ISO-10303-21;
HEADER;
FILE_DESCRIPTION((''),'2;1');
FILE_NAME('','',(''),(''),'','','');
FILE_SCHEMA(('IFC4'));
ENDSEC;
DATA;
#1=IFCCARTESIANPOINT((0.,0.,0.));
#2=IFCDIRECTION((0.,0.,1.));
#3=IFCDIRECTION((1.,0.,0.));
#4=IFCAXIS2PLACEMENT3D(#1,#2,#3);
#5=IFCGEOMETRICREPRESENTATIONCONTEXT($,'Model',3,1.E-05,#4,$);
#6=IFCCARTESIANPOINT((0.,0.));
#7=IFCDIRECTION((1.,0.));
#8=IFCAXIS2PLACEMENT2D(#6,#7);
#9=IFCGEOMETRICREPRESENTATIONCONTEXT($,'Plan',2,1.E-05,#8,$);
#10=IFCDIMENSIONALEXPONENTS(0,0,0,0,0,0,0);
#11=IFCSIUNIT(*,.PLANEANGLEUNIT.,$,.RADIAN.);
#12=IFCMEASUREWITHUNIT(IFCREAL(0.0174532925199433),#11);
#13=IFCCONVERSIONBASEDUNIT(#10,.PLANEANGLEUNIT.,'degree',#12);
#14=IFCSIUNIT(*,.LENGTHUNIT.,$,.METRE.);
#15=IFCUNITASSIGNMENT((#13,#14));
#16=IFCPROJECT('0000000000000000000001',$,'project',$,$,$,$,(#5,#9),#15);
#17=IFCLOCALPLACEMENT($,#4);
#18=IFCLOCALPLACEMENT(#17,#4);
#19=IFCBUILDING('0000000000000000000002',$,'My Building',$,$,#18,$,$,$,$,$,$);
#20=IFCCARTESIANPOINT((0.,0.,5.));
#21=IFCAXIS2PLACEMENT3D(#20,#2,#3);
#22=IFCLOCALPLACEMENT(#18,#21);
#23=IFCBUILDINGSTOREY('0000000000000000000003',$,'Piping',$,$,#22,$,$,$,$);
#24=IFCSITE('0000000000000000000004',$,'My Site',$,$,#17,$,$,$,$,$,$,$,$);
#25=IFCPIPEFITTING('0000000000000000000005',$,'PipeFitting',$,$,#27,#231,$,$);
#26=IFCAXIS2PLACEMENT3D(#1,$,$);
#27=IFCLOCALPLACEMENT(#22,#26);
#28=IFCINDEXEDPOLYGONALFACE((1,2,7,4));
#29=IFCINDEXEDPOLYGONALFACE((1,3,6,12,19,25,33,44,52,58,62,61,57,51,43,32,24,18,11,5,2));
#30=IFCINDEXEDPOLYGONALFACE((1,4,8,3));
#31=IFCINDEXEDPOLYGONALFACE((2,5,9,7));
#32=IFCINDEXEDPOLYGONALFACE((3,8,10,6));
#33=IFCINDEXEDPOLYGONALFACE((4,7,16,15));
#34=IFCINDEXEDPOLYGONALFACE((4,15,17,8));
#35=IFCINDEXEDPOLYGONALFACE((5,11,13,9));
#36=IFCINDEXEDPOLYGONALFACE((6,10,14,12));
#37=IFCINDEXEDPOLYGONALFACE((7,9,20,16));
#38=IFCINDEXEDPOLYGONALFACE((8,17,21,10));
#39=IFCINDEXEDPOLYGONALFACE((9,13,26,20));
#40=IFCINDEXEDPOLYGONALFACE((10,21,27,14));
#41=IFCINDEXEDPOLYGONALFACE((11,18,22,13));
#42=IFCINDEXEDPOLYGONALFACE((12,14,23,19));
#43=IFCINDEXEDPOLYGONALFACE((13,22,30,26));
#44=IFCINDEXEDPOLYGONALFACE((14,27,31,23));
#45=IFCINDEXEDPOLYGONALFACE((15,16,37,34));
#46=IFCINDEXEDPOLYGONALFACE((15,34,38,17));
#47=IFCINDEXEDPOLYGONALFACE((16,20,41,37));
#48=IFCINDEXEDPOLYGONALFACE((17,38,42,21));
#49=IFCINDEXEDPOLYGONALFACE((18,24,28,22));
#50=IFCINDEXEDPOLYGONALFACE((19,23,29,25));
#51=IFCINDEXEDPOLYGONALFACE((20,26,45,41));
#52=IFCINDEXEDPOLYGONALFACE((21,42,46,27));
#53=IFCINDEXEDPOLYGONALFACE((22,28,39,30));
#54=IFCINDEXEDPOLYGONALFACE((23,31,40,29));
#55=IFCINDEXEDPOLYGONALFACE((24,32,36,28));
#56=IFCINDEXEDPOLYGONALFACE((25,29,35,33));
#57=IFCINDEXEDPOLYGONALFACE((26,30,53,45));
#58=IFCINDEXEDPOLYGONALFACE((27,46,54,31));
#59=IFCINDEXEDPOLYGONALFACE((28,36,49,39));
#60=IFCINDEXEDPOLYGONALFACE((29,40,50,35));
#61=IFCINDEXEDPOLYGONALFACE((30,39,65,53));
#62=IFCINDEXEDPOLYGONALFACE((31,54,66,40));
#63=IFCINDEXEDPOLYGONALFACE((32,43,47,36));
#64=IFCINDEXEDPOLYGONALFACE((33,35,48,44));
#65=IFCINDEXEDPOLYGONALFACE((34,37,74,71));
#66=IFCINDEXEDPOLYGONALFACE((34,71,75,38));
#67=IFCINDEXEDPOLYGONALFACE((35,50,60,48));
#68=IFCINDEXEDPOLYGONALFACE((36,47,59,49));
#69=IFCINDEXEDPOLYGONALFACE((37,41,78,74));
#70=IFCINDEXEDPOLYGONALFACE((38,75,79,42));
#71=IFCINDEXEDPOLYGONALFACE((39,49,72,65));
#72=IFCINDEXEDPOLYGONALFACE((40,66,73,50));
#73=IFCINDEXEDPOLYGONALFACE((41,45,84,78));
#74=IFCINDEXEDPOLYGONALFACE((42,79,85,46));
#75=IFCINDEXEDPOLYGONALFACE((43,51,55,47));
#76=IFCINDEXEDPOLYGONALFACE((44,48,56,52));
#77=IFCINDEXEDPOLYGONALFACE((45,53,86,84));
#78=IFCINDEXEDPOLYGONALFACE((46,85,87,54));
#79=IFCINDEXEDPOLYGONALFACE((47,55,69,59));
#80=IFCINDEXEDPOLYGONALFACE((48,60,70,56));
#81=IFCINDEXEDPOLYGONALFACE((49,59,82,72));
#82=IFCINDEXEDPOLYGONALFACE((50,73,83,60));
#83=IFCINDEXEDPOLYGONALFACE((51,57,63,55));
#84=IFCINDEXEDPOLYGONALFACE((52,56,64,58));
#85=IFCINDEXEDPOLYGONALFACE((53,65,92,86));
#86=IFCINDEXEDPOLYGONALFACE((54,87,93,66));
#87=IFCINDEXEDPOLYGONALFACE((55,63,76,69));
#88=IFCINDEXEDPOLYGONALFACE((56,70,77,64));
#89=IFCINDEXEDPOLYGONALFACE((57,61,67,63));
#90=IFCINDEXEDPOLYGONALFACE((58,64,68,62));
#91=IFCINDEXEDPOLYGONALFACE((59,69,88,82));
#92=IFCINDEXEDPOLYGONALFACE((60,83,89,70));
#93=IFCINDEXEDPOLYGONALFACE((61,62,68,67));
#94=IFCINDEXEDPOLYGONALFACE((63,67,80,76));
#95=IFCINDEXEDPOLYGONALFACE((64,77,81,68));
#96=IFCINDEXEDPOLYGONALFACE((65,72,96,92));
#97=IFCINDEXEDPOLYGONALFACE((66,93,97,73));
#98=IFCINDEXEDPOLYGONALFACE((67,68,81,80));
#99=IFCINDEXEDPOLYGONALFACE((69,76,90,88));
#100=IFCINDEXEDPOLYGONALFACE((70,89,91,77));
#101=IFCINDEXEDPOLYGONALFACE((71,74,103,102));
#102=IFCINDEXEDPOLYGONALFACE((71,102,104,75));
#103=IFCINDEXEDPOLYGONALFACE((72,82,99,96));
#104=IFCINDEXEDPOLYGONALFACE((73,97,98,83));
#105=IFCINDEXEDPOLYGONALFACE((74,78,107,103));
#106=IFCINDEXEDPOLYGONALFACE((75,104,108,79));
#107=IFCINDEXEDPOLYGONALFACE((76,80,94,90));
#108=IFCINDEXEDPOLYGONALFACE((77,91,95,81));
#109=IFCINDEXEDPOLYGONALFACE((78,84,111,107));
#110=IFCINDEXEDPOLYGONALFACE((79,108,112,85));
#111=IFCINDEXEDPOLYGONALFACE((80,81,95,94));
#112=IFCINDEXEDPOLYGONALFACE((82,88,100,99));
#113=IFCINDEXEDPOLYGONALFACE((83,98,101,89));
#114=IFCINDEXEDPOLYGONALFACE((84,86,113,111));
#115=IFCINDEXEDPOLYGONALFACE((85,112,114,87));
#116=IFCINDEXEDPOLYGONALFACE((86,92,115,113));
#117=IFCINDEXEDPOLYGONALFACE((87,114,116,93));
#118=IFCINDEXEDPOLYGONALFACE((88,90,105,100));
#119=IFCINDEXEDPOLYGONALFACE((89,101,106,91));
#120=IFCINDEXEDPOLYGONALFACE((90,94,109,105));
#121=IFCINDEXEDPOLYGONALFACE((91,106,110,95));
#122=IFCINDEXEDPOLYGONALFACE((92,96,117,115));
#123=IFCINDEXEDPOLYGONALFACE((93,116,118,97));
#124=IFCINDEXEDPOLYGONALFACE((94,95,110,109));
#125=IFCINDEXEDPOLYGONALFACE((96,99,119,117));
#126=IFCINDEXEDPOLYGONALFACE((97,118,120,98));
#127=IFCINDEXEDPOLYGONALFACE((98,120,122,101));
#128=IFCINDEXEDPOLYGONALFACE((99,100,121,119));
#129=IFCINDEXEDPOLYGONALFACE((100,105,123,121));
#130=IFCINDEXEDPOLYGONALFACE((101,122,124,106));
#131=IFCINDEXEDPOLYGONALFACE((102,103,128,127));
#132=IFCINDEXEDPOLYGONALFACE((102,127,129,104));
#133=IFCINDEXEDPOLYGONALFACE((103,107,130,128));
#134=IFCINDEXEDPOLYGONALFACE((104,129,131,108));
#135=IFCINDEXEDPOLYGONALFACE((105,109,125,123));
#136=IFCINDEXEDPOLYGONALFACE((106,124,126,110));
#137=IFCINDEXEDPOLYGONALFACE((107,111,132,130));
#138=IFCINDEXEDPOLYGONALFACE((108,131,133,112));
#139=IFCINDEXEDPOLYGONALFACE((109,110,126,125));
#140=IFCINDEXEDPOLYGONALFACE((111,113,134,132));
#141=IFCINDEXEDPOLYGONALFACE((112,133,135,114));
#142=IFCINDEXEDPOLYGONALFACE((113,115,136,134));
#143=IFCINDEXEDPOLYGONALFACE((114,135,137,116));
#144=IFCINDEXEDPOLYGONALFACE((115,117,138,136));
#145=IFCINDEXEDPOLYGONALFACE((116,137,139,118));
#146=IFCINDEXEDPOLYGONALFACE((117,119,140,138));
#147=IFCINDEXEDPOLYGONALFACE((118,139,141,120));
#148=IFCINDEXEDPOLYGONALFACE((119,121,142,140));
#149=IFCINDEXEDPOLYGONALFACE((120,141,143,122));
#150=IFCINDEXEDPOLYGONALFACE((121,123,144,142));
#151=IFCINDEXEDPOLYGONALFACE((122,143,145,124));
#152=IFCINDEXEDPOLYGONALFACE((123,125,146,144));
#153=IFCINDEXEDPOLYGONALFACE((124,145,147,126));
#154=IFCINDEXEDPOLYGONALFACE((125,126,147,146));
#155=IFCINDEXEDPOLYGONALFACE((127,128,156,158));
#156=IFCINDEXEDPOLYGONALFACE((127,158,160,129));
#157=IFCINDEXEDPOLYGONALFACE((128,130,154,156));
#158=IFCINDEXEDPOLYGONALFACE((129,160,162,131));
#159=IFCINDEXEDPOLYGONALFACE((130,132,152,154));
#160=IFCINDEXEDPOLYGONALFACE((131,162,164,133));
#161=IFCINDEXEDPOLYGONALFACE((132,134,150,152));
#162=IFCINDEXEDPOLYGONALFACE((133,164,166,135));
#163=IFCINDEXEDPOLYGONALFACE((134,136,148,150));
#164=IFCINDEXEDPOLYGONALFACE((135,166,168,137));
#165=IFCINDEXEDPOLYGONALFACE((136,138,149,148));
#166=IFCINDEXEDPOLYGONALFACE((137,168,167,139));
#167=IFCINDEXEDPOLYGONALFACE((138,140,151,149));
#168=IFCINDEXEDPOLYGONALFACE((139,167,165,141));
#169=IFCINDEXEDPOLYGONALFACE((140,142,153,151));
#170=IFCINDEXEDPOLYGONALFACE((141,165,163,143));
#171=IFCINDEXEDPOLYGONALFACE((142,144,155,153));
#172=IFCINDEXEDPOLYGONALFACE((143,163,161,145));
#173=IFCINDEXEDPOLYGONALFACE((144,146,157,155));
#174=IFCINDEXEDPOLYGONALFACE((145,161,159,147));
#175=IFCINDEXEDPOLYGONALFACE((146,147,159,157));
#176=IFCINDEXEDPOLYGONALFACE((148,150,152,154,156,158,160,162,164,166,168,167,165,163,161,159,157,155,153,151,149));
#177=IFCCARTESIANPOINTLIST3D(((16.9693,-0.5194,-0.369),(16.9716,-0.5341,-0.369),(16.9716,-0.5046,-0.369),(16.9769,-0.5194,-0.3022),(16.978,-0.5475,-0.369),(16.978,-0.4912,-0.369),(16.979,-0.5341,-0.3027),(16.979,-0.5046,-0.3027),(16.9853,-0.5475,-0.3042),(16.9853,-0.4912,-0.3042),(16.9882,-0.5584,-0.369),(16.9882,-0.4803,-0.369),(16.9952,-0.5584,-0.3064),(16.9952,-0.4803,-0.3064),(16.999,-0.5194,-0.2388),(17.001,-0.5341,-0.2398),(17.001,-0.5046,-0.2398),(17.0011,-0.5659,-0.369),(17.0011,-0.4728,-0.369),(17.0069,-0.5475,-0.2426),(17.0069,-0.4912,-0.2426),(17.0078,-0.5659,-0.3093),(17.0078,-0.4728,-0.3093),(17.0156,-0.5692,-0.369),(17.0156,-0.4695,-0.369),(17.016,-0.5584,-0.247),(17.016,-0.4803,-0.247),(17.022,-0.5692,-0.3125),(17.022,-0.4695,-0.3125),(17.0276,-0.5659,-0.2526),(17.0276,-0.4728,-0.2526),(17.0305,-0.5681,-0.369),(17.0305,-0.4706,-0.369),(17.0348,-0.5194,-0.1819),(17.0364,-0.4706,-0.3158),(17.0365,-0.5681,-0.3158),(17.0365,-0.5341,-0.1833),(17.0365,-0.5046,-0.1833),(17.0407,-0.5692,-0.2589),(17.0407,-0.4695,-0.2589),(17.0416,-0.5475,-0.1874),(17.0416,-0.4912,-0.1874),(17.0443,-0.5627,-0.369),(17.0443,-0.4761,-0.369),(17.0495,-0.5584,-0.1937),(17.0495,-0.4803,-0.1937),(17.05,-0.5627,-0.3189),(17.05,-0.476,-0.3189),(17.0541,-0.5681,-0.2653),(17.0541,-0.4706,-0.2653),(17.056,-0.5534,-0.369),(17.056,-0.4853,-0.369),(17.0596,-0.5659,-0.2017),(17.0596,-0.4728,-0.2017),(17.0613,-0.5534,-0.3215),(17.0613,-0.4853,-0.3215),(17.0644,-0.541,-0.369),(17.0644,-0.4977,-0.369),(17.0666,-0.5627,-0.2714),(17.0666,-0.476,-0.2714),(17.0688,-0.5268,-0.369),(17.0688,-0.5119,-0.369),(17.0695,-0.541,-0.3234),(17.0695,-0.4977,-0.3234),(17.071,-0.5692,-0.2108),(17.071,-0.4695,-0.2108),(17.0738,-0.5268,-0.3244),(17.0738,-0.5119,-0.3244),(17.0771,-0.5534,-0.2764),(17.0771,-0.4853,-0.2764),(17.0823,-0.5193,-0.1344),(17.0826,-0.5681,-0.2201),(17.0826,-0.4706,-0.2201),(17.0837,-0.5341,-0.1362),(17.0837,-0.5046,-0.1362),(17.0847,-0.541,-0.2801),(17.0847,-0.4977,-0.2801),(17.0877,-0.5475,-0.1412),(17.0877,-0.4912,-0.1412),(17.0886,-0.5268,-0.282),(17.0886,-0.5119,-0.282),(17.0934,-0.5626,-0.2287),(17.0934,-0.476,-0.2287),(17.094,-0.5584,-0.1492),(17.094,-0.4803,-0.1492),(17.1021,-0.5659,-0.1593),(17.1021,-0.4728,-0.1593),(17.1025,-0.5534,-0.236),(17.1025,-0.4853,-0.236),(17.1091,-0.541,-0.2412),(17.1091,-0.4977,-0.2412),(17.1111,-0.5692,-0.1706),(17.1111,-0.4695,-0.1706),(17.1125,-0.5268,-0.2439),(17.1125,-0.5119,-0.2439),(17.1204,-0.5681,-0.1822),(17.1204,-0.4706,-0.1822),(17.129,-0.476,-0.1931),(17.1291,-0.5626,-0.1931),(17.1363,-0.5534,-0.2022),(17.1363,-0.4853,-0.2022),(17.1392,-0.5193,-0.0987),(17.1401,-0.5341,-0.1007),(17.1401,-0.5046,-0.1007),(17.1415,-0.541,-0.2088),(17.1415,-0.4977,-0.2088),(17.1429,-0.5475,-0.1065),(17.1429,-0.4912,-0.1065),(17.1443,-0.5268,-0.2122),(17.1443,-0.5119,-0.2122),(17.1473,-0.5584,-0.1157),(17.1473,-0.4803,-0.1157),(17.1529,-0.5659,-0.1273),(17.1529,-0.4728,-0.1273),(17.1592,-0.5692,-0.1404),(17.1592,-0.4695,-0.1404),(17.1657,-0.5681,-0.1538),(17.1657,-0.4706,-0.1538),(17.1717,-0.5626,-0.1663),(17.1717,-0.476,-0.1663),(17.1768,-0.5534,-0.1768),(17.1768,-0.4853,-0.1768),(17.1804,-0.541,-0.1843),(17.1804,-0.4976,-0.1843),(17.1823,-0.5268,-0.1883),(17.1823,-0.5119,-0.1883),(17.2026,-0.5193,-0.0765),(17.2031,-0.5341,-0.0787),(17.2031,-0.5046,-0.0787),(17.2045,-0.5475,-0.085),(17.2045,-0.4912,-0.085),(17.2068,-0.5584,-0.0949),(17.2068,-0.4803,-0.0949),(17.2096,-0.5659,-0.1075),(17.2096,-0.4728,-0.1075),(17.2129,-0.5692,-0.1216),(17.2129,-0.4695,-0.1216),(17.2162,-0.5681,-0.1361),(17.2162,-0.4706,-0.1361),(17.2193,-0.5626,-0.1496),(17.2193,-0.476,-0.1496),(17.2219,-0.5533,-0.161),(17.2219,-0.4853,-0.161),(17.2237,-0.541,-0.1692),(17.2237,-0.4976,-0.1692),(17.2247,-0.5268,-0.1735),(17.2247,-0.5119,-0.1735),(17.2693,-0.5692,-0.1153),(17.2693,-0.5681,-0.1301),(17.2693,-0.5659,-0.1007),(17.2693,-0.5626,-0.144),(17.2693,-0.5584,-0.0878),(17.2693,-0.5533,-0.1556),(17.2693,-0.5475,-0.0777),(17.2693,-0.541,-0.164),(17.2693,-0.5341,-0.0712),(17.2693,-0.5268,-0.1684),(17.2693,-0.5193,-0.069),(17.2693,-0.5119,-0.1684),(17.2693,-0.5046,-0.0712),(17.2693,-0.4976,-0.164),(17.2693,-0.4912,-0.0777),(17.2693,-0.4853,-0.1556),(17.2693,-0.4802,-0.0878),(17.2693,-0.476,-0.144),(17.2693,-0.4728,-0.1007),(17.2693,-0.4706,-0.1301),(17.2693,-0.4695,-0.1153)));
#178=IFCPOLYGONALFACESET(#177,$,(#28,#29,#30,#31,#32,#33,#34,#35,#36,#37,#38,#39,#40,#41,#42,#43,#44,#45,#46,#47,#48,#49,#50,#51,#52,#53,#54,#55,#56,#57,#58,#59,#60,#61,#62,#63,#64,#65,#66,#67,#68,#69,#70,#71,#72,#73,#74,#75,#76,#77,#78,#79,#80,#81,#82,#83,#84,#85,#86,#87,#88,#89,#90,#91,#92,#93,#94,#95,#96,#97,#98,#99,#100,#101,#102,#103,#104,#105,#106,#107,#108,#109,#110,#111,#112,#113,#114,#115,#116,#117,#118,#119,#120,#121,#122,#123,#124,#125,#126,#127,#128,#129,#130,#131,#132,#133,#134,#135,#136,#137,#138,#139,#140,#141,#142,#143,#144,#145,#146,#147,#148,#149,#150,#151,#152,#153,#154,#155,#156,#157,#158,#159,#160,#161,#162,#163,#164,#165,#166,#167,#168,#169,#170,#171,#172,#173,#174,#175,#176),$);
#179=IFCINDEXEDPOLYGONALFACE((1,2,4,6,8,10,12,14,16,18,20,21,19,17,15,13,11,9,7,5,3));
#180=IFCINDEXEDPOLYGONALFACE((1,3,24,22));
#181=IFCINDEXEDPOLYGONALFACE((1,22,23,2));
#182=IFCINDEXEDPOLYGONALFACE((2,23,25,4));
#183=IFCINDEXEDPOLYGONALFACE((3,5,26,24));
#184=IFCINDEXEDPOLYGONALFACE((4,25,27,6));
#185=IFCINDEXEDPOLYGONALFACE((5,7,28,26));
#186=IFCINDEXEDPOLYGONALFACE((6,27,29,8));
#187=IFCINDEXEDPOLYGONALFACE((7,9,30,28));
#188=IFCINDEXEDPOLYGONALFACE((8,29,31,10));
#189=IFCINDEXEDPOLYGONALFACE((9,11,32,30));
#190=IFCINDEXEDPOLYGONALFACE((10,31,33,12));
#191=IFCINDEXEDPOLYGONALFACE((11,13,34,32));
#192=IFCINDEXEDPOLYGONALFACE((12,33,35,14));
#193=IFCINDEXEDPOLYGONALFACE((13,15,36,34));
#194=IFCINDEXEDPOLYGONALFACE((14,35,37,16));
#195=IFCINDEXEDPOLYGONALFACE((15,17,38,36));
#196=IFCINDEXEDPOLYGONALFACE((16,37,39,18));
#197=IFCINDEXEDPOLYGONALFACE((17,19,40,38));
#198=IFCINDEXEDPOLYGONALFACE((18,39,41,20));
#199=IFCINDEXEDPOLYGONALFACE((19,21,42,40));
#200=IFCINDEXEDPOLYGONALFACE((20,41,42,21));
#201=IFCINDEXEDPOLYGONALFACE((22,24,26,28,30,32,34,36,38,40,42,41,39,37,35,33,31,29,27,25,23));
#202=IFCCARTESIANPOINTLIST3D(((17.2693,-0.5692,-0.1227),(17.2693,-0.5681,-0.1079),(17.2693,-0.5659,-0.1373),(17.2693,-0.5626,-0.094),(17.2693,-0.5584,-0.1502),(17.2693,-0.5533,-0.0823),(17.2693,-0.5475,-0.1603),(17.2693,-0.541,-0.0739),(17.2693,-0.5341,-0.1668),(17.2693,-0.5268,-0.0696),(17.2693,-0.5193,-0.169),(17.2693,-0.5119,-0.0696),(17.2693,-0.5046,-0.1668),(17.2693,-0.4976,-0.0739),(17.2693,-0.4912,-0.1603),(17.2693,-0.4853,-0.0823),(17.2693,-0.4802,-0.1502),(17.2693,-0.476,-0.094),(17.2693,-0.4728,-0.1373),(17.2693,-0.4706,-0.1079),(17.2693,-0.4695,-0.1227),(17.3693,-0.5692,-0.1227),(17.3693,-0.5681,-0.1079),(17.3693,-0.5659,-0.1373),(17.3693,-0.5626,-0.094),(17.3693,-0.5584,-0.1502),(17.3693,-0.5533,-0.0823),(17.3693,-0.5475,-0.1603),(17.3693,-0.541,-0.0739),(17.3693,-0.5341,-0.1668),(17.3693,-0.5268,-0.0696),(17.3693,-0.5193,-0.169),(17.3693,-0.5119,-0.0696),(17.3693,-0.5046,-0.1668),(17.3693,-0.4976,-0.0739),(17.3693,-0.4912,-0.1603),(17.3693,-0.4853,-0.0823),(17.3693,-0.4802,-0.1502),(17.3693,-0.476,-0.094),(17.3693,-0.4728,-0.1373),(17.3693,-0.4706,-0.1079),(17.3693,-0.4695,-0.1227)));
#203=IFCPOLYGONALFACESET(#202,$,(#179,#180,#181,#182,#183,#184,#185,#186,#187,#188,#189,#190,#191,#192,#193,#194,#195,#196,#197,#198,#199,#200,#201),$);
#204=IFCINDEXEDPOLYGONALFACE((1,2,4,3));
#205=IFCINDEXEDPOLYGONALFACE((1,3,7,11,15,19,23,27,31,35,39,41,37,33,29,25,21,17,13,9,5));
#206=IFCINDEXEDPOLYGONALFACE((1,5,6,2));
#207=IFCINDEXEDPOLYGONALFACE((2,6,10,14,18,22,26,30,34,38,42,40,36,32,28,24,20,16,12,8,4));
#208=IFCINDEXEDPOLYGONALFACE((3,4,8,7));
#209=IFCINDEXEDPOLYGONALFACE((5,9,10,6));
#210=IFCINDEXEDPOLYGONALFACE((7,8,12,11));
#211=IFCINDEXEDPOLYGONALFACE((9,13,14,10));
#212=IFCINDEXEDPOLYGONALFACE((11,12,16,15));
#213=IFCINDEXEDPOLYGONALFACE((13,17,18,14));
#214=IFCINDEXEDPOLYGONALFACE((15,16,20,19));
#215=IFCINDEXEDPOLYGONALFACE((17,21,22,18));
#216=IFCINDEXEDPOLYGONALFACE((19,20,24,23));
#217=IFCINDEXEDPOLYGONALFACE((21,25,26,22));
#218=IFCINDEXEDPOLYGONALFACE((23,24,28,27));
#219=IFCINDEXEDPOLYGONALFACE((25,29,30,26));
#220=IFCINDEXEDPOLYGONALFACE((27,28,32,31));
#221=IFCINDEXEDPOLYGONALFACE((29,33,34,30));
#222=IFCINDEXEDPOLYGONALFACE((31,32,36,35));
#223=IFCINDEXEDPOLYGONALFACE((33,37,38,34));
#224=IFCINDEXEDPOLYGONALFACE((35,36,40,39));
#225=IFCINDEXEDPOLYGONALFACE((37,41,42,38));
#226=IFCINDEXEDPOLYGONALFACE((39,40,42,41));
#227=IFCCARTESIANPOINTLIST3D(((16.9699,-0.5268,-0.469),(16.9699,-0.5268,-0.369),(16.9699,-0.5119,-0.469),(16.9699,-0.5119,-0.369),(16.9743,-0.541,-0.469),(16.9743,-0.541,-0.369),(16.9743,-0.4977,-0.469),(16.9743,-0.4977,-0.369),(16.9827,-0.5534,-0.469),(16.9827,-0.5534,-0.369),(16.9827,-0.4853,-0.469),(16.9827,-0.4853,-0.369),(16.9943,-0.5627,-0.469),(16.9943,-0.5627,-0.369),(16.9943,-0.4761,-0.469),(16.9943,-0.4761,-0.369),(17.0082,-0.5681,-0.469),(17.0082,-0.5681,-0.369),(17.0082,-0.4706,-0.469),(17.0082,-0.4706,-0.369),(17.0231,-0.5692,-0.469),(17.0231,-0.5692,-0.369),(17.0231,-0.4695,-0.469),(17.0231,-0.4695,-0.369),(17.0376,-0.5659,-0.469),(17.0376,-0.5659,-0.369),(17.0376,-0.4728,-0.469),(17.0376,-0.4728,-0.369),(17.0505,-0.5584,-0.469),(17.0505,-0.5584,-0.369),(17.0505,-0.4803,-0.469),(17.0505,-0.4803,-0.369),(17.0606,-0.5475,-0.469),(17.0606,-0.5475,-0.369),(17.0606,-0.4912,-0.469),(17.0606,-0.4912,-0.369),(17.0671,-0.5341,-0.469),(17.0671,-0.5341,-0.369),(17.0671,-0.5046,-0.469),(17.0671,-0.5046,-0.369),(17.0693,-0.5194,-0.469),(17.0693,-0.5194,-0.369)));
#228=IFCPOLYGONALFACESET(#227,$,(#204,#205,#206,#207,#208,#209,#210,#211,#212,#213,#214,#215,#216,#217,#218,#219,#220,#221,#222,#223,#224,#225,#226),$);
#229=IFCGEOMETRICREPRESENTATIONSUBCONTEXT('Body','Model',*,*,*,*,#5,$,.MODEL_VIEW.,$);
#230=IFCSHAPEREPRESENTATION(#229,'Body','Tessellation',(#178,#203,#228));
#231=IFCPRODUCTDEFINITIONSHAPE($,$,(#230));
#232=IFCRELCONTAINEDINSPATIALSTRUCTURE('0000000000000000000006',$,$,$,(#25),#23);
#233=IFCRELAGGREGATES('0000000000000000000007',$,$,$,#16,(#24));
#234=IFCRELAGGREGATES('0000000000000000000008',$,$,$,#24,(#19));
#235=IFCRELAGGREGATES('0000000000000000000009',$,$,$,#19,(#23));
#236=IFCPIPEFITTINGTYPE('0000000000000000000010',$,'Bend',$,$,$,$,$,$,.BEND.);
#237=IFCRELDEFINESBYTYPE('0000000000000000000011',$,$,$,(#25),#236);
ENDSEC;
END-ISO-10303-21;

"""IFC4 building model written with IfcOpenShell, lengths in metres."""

from ifc_helpers import new_model, entity, si_unit, converted_unit, frame, origin_with_axes, origin_2d_with_axis, place, context, subcontext, project, spatial, circle, extrude, source, transform, mapped, type_object, type_shapes, element, save


model = new_model("IFC4")

# Units and contexts
model_context = context("Model", 3, precision=1e-05, world=origin_with_axes())
plan_context = context("Plan", 2, precision=1e-05, world=origin_2d_with_axis())
body_context = subcontext(model_context, "Body", "Model", "MODEL_VIEW")
ifc_project = project(units=[converted_unit("PLANEANGLEUNIT", "degree", entity("IfcReal", 0.0174532925199433), si_unit("PLANEANGLEUNIT", "RADIAN"), dimensions=[0, 0, 0, 0, 0, 0, 0]), si_unit("LENGTHUNIT", "METRE")], contexts=[model_context, plan_context])

# Site, building, storey
site_placement = place(None, origin_with_axes())
site = spatial("IfcSite", under=ifc_project, at=site_placement, Name="My Site")
building_placement = place(site_placement, origin_with_axes())
building = spatial("IfcBuilding", under=site, at=building_placement, Name="My Building")
storey_placement = place(building_placement, frame((0.0, 0.0, 5.0), z_axis=(0.0, 0.0, 1.0), x_axis=(1.0, 0.0, 0.0)))
storey = spatial("IfcBuildingStorey", under=building, at=storey_placement, Name="Piping")

# Pipe fitting
pipe_fitting_type_1 = type_object("IfcPipeFittingType", Name="Bend", PredefinedType="BEND")
shared_shape = source(origin_with_axes(), body_context, "Body", "SolidModel", [
    entity("IfcSweptDiskSolid", entity("IfcIndexedPolyCurve", entity("IfcCartesianPointList3D", [[0.0, 0.0, -0.1], [0.0732, 0.0, -0.2768], [0.25, 0.0, -0.35]]), [entity("IfcArcIndex", [1, 2, 3])]), 0.05),
    extrude(circle(Radius=0.05), origin_with_axes(), (0.0, 0.0, -1.0), 0.1),
    extrude(circle(Radius=0.05), frame((0.25, 0.0, -0.35), z_axis=(1.0, 0.0, 0.0), x_axis=(0.0, 0.0, 1.0)), (0.0, 0.0, 1.0), 0.1),
])
type_shapes(pipe_fitting_type_1, [shared_shape])
for number, where, z_axis, x_axis, name in (
    (1, (17.3693, -0.5193, -0.119), (1.0, 0.00006, 0.0), (0.0, 0.0, -1.0), "PipeFitting"),
):
    element("IfcPipeFitting", number, at=place(storey_placement, frame(where, z_axis=z_axis, x_axis=x_axis)), inside=storey, type_object=pipe_fitting_type_1, Name=name, context=body_context, shape_type="MappedRepresentation", body=[
        mapped(shared_shape, transform((0.0, 0.0, 0.0), x_axis=(1.0, 0.0, 0.0), y_axis=(0.0, 1.0, 0.0), z_axis=(0.0, 0.0, 1.0), scale=1.0)),
    ])

save(model, "model.ifc")
